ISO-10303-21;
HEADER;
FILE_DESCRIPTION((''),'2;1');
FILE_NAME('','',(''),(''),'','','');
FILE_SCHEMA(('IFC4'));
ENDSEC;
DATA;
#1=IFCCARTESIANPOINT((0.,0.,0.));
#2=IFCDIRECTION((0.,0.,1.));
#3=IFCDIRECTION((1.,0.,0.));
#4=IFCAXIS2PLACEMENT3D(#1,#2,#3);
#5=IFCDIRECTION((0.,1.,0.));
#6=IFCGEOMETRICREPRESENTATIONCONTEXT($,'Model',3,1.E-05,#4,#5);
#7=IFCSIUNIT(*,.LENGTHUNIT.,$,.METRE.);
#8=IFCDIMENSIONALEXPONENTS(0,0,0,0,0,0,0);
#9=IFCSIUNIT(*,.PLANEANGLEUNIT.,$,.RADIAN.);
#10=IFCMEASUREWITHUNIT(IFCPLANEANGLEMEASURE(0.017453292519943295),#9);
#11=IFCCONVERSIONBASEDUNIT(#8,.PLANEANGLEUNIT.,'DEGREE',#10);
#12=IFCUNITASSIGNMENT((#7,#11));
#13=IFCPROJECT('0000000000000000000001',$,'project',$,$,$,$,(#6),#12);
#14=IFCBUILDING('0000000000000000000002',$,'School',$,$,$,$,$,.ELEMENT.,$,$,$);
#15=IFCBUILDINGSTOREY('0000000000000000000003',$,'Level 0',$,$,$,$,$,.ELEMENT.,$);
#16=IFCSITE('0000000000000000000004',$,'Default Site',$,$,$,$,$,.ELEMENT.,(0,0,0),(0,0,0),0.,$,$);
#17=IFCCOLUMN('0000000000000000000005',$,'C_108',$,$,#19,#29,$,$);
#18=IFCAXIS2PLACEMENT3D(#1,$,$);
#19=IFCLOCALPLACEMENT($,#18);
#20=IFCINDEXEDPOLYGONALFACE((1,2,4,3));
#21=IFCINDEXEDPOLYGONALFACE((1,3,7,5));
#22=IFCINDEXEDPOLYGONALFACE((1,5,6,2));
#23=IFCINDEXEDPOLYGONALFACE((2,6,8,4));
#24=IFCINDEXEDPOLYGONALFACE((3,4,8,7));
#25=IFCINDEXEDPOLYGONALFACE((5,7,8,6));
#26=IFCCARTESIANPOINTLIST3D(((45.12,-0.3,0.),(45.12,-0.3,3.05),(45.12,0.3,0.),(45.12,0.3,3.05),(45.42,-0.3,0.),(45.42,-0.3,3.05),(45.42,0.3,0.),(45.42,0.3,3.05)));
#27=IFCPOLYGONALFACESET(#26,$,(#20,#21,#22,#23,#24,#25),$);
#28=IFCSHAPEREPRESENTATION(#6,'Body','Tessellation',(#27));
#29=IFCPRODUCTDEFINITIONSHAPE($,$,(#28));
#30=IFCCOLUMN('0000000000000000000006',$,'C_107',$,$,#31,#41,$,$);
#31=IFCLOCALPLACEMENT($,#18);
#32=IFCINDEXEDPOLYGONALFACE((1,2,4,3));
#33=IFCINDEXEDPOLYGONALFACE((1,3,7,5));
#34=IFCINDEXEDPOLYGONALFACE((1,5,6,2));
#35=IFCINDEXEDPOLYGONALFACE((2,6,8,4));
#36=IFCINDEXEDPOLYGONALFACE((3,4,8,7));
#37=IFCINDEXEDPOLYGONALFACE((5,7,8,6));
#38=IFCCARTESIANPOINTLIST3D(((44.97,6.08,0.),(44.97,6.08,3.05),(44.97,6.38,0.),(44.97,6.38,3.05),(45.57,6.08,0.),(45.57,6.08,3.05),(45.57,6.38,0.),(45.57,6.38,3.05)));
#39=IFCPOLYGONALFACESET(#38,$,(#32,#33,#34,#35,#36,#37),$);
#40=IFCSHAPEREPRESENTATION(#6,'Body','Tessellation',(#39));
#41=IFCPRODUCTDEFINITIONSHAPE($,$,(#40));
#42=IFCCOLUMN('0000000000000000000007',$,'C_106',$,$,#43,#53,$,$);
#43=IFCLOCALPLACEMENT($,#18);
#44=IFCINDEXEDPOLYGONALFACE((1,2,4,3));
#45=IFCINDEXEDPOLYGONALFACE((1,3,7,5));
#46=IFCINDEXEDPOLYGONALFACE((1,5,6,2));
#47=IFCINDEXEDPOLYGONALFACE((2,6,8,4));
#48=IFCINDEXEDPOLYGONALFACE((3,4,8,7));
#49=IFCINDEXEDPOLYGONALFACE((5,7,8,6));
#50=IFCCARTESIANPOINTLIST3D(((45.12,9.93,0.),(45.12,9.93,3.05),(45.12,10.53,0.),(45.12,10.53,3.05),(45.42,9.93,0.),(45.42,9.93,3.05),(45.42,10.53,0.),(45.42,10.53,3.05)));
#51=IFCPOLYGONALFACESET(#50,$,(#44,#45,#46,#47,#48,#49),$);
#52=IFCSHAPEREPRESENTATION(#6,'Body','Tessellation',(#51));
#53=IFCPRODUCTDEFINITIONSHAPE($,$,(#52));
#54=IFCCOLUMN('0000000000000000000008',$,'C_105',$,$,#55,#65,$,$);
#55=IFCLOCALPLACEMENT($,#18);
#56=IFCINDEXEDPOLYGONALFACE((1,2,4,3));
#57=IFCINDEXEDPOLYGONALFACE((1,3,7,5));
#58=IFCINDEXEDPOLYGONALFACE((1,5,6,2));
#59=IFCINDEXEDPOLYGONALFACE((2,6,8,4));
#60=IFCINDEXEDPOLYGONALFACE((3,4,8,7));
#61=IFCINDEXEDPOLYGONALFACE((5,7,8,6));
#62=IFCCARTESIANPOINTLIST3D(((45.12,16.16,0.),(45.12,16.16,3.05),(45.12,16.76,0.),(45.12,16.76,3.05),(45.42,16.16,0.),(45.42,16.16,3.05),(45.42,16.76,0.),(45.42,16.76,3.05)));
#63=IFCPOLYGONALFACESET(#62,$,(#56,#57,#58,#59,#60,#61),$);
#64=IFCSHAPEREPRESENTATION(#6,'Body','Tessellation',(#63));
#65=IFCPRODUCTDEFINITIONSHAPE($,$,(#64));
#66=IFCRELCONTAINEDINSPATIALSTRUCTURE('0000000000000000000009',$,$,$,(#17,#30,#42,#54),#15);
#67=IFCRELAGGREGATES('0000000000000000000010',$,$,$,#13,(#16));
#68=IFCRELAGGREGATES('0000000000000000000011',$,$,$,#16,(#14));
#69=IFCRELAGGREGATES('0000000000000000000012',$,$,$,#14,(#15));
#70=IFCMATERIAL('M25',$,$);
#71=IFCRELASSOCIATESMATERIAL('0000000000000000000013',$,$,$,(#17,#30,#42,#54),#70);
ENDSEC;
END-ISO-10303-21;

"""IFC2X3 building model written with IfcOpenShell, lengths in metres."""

from ifc_helpers import new_model, entity, si_unit, converted_unit, direction, frame, frame_2d, origin_with_axes, place, context, project, spatial, rectangle, extrude, material, element, save


model = new_model("IFC2X3")

# Units and contexts
model_context = context("Model", 3, precision=1e-05, world=origin_with_axes(), true_north=direction((0.0, 1.0, 0.0)))
ifc_project = project(units=[si_unit("LENGTHUNIT", "METRE"), converted_unit("PLANEANGLEUNIT", "DEGREE", entity("IfcPlaneAngleMeasure", 0.017453292519943295), si_unit("PLANEANGLEUNIT", "RADIAN"), dimensions=[0, 0, 0, 0, 0, 0, 0])], contexts=[model_context])

# Site, building, storey
site = spatial("IfcSite", under=ifc_project, Name="Default Site", CompositionType="ELEMENT", RefLatitude=(0, 0, 0), RefLongitude=(0, 0, 0), RefElevation=0.0)
building = spatial("IfcBuilding", under=site, Name="School", CompositionType="ELEMENT")
storey = spatial("IfcBuildingStorey", under=building, Name="Level 0", CompositionType="ELEMENT")

# Columns
ifc_material = material(Name="M25")
placement = place(None, origin_with_axes())
element("IfcColumn", 1, at=placement, inside=storey, material=ifc_material, Name="C_108", context=model_context, shape_type="SweptSolid", body=[
    extrude(rectangle(XDim=0.3, YDim=0.6, at=frame_2d((0.0, 0.0), x_axis=(1.0, 0.0, 0.0))), frame((45.27, 0.0, 0.0), z_axis=(0.0, 0.0, 1.0), x_axis=(1.0, 0.0, 0.0)), (0.0, 0.0, 1.0), 3.05),
])
element("IfcColumn", 2, at=placement, inside=storey, material=ifc_material, Name="C_107", context=model_context, shape_type="SweptSolid", body=[
    extrude(rectangle(XDim=0.6, YDim=0.3, at=frame_2d((0.0, 0.0), x_axis=(1.0, 0.0, 0.0))), frame((45.27, 6.23, 0.0), z_axis=(0.0, 0.0, 1.0), x_axis=(1.0, 0.0, 0.0)), (0.0, 0.0, 1.0), 3.05),
])
element("IfcColumn", 3, at=placement, inside=storey, material=ifc_material, Name="C_106", context=model_context, shape_type="SweptSolid", body=[
    extrude(rectangle(XDim=0.3, YDim=0.6, at=frame_2d((0.0, 0.0), x_axis=(1.0, 0.0, 0.0))), frame((45.27, 10.23, 0.0), z_axis=(0.0, 0.0, 1.0), x_axis=(1.0, 0.0, 0.0)), (0.0, 0.0, 1.0), 3.05),
])
element("IfcColumn", 4, at=placement, inside=storey, material=ifc_material, Name="C_105", context=model_context, shape_type="SweptSolid", body=[
    extrude(rectangle(XDim=0.3, YDim=0.6, at=frame_2d((0.0, 0.0), x_axis=(1.0, 0.0, 0.0))), frame((45.27, 16.46, 0.0), z_axis=(0.0, 0.0, 1.0), x_axis=(1.0, 0.0, 0.0)), (0.0, 0.0, 1.0), 3.05),
])

save(model, "model.ifc")
